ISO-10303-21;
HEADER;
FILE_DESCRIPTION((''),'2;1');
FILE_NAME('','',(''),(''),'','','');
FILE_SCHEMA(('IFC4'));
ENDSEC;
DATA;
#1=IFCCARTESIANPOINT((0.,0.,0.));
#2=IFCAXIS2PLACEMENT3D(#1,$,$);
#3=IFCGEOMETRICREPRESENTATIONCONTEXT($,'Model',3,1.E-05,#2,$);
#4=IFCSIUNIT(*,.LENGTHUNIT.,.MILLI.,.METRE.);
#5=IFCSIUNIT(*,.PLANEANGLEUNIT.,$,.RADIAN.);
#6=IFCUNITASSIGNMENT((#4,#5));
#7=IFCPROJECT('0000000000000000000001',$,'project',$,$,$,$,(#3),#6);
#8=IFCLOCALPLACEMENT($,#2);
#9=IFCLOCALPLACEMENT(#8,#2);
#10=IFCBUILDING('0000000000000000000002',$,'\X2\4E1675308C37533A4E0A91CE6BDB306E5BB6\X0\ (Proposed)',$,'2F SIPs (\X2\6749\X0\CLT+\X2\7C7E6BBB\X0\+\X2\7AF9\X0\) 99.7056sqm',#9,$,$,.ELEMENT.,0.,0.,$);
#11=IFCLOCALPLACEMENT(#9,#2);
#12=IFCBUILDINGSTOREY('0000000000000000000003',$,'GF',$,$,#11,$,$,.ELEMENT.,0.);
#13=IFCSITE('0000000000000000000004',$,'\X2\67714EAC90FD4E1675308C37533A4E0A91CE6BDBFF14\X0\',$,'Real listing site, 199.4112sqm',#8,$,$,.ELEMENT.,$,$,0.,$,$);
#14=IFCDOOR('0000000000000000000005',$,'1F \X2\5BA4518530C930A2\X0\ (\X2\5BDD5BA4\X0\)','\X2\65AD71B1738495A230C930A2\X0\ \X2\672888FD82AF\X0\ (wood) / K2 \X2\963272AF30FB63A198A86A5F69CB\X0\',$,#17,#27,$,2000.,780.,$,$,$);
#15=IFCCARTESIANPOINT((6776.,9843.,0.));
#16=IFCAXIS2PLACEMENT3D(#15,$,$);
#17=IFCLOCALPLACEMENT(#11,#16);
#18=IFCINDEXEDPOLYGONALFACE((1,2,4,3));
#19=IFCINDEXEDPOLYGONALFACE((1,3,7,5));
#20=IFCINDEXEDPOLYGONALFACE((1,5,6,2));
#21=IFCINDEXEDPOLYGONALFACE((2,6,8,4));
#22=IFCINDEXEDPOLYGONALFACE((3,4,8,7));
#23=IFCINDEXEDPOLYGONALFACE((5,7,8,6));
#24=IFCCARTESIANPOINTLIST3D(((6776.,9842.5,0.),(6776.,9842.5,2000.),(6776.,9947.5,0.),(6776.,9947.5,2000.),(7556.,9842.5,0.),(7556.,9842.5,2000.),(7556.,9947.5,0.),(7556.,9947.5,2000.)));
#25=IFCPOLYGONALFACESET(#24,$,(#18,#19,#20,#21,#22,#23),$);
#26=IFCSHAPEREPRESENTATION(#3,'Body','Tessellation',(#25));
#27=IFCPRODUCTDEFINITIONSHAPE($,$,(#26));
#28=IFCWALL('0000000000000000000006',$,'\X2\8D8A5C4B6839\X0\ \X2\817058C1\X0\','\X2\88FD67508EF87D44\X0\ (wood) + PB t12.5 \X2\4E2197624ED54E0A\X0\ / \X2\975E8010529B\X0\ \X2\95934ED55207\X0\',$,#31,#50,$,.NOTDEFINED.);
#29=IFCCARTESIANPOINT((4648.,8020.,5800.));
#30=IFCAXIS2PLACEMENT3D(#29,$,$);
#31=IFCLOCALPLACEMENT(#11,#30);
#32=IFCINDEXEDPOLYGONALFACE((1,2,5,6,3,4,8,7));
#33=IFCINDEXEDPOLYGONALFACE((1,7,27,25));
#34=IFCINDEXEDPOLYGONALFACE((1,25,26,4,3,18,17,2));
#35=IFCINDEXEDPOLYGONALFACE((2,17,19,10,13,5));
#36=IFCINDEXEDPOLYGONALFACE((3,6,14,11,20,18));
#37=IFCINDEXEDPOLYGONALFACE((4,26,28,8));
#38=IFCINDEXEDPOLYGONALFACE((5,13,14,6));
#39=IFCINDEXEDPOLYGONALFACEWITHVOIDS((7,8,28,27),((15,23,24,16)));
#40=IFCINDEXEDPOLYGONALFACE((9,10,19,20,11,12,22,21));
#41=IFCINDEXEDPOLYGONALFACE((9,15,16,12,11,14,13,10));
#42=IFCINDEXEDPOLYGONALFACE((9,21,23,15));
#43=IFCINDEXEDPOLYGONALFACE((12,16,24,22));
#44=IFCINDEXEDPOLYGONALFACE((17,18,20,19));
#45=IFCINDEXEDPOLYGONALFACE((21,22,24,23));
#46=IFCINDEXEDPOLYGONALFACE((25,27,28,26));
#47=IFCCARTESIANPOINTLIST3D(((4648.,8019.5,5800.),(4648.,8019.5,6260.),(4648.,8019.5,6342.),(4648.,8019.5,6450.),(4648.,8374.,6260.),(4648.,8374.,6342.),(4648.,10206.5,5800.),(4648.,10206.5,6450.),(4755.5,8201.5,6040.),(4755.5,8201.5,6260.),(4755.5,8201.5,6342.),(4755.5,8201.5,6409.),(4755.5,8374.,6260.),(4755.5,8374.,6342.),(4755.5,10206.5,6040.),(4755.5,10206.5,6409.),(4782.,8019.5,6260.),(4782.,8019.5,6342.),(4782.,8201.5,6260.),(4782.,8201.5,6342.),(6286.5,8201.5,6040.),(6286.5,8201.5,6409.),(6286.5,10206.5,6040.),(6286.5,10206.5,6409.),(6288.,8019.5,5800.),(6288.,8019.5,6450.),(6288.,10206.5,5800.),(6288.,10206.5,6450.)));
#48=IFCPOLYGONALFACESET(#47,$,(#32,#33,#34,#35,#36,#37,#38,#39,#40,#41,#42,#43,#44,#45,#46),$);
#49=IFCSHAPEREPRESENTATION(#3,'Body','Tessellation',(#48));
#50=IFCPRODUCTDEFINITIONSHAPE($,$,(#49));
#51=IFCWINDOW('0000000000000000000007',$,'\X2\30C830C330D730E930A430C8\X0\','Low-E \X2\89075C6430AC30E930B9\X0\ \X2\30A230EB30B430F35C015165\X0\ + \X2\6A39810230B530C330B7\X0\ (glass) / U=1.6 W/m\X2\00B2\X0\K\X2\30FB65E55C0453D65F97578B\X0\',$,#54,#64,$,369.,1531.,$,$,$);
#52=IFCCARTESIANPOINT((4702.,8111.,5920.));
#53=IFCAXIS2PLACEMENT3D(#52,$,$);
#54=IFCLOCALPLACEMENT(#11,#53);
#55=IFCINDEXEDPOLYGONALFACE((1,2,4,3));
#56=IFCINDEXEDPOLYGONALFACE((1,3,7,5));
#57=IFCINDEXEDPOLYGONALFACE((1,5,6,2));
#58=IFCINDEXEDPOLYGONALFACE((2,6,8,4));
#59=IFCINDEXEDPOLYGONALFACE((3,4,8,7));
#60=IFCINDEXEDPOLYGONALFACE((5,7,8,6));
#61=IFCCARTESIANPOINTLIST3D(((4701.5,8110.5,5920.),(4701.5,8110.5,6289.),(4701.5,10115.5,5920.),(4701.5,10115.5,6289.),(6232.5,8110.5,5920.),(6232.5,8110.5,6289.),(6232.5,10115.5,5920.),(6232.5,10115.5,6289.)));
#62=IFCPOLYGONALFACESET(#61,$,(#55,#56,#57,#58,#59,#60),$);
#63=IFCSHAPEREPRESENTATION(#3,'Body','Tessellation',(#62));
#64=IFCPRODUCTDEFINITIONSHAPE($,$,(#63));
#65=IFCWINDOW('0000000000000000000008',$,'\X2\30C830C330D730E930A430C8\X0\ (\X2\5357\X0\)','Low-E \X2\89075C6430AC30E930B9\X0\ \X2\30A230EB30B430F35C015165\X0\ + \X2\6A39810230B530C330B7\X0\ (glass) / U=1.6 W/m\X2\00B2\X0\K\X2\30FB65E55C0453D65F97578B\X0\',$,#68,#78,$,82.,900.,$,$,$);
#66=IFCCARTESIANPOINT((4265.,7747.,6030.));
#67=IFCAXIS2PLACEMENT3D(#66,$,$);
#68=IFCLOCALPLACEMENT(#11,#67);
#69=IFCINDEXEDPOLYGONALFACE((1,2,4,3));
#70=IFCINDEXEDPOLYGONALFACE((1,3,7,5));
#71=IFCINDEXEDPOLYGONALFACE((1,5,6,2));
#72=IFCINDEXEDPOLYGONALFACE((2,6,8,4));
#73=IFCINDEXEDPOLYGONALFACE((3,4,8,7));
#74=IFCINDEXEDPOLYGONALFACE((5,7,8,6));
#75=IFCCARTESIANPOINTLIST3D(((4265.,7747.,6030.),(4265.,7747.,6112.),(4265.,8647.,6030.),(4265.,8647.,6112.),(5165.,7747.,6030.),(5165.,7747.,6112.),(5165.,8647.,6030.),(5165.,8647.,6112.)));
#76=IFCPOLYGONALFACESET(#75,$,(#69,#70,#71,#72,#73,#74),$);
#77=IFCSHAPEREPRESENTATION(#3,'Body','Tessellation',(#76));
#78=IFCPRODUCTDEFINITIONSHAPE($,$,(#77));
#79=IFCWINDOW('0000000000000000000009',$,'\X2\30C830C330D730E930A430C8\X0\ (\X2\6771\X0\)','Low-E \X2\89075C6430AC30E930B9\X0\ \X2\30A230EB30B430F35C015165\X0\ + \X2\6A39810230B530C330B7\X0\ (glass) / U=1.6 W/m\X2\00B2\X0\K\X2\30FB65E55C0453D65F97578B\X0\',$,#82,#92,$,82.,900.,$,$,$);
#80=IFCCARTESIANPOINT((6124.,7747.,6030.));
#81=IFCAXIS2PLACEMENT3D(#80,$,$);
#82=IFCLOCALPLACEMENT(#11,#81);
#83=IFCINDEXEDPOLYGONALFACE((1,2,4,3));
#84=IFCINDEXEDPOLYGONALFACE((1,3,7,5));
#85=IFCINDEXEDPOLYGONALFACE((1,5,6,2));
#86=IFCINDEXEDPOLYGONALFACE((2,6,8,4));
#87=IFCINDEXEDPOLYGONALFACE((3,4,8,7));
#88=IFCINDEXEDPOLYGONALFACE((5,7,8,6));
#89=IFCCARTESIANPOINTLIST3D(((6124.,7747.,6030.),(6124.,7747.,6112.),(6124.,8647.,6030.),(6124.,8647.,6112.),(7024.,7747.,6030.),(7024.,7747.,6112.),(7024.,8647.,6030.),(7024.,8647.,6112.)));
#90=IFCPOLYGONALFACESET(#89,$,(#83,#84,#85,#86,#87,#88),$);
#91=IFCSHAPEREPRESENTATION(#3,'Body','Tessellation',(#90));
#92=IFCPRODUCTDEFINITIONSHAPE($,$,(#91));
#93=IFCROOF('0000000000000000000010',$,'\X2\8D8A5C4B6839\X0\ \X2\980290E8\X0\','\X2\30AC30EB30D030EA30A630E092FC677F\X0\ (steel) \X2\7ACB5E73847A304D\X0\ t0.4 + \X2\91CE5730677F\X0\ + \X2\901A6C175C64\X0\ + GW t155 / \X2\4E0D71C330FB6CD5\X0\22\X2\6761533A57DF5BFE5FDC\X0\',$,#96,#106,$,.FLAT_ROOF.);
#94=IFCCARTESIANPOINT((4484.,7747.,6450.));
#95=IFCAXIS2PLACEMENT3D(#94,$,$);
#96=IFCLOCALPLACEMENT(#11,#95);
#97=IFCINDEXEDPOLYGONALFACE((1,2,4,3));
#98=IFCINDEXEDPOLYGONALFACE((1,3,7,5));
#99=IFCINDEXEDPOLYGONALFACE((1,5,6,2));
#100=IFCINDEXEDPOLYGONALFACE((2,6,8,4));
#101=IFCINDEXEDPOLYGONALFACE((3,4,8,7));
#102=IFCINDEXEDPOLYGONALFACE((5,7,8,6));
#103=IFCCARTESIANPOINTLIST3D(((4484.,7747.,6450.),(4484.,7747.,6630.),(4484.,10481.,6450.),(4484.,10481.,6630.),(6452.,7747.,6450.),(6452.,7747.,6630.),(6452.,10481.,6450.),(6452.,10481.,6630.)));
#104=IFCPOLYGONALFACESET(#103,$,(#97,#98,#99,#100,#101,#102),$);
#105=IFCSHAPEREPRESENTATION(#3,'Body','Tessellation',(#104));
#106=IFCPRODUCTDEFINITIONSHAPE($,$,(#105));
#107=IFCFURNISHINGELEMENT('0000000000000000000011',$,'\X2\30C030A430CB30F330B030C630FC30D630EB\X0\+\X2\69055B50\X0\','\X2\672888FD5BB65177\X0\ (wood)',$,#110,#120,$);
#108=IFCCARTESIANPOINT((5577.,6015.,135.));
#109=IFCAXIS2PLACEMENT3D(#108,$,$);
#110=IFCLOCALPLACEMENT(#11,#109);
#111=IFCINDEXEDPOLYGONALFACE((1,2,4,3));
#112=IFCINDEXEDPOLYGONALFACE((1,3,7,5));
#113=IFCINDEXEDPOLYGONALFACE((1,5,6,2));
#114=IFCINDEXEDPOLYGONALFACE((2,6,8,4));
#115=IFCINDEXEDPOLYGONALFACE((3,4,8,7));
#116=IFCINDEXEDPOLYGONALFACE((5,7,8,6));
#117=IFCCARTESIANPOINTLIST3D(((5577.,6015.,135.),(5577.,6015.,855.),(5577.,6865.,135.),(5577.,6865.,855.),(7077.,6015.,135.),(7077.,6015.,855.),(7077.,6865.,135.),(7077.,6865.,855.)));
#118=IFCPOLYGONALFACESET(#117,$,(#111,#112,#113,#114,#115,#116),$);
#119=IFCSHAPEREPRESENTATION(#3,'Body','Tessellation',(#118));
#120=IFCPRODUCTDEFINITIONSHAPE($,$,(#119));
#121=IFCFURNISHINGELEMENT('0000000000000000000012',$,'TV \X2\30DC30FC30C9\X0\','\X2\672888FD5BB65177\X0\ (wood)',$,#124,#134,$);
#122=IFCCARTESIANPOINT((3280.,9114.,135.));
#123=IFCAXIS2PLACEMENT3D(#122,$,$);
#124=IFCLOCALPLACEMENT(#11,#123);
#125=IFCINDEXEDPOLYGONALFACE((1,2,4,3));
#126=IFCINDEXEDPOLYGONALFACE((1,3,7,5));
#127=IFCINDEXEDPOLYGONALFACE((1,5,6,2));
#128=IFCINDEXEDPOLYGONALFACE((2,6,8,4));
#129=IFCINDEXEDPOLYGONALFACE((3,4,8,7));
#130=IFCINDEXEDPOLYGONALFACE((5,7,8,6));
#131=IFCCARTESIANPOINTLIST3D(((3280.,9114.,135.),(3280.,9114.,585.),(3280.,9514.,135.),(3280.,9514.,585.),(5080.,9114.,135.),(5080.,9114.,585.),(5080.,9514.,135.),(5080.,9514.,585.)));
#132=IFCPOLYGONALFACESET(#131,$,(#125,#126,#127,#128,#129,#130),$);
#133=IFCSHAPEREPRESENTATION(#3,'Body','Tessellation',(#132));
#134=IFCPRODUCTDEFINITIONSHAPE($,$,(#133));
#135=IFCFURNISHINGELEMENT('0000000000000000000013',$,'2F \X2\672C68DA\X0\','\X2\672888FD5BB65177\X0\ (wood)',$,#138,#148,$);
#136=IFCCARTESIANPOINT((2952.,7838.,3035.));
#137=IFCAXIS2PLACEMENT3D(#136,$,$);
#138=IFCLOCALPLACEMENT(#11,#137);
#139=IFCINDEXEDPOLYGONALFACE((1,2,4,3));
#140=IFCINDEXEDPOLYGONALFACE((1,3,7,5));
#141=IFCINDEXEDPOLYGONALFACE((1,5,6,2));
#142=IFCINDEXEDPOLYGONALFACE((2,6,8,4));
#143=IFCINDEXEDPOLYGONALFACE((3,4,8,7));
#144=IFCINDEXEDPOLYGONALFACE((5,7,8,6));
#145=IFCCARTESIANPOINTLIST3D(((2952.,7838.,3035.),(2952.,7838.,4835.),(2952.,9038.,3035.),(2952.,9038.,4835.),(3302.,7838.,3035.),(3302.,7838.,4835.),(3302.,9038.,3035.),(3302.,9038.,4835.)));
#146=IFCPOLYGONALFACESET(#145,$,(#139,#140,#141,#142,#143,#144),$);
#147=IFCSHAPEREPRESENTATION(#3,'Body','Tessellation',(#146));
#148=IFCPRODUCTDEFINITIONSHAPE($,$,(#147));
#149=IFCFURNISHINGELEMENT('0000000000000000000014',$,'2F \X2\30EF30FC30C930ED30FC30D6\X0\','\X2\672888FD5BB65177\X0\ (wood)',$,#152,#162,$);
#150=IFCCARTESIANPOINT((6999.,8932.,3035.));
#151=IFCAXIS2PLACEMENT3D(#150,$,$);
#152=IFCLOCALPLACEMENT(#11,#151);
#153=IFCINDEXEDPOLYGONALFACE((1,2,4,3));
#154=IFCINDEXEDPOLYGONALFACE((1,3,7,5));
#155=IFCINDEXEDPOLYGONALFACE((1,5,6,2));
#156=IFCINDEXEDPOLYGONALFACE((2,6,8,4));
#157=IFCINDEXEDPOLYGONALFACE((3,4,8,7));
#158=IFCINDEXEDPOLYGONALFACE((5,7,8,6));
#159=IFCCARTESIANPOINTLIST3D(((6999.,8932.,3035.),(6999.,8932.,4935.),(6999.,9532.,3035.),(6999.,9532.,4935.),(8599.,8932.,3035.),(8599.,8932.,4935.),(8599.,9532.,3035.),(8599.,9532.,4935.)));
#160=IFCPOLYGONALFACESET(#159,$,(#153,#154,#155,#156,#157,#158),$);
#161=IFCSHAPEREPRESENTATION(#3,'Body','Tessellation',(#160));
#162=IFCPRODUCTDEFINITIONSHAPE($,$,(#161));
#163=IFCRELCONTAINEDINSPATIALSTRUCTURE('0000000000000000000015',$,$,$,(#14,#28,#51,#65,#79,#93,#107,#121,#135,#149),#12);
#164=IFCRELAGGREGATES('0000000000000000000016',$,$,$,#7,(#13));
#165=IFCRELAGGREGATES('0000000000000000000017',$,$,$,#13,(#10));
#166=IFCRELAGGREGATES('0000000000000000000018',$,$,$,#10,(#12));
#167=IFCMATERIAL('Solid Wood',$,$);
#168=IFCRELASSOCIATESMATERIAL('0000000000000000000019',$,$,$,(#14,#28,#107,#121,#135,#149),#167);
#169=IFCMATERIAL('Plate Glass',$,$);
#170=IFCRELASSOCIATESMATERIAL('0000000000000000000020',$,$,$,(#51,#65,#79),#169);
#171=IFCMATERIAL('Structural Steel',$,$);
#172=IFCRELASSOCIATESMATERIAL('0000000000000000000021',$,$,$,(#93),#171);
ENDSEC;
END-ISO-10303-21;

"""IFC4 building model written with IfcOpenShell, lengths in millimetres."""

from ifc_helpers import new_model, si_unit, frame, frame_2d, origin, place, context, project, spatial, rectangle, extrude, material, element, fill, save


model = new_model("IFC4")

# Units and contexts
model_context = context("Model", 3, precision=1e-05, world=origin())
ifc_project = project(units=[si_unit("LENGTHUNIT", "METRE", prefix="MILLI"), si_unit("PLANEANGLEUNIT", "RADIAN")], contexts=[model_context])

# Site, building, storey
site_placement = place(None, origin())
site = spatial("IfcSite", under=ifc_project, at=site_placement, Name="東京都世田谷区上野毛４", ObjectType="Real listing site, 199.4112sqm", CompositionType="ELEMENT", RefElevation=0.0)
building_placement = place(site_placement, origin())
building = spatial("IfcBuilding", under=site, at=building_placement, Name="世田谷区上野毛の家 (Proposed)", ObjectType="2F SIPs (杉CLT+籾殻+竹) 99.7056sqm", CompositionType="ELEMENT", ElevationOfRefHeight=0.0, ElevationOfTerrain=0.0)
storey_placement = place(building_placement, origin())
storey = spatial("IfcBuildingStorey", under=building, at=storey_placement, Name="GF", CompositionType="ELEMENT", Elevation=0.0)

# Shared definitions
ifc_material_1 = material(Name="Solid Wood")

# Door
door_placement = place(storey_placement, frame((6776.0, 9843.0, 0.0)))
element("IfcDoor", 1, at=door_placement, inside=storey, material=ifc_material_1, Name="1F 室内ドア (寝室)", Description="断熱玄関ドア 木製芯 (wood) / K2 防犯・採風機構", OverallHeight=2000.0, OverallWidth=780.0, context=model_context, shape_type="SweptSolid", body=[
    extrude(rectangle(XDim=780.0, YDim=105.0, at=frame_2d((390.0, 52.0))), frame((6776.0, 9843.0, 0.0)), (0.0, 0.0, 1.0), 2000.0),
])

# Wall, openings, windows
wall_1_placement = place(storey_placement, frame((4648.0, 8020.0, 5800.0)))
wall_1 = element("IfcWall", 2, at=wall_1_placement, inside=storey, material=ifc_material_1, Name="越屋根 腰壁", Description="製材軸組 (wood) + PB t12.5 両面仕上 / 非耐力 間仕切", PredefinedType="NOTDEFINED", context=model_context, shape_type="SweptSolid", body=[
    extrude(rectangle(XDim=1640.0, YDim=2187.0, at=frame_2d((820.0, 1093.0))), frame((4648.0, 8020.0, 5800.0)), (0.0, 0.0, 1.0), 650.0),
])
opening_1_placement = place(storey_placement, frame((4702.0, 8111.0, 5920.0)))
opening_1 = element("IfcOpeningElement", 3, at=opening_1_placement, cuts=wall_1, PredefinedType="NOTDEFINED", context=model_context, shape_type="SweptSolid", body=[
    extrude(rectangle(XDim=1531.0, YDim=2005.0, at=frame_2d((765.0, 1002.0))), frame((4702.0, 8111.0, 5920.0)), (0.0, 0.0, 1.0), 369.0),
])
opening_2_placement = place(storey_placement, frame((4265.0, 7747.0, 6030.0)))
opening_2 = element("IfcOpeningElement", 4, at=opening_2_placement, cuts=wall_1, PredefinedType="NOTDEFINED", context=model_context, shape_type="SweptSolid", body=[
    extrude(rectangle(XDim=900.0, YDim=900.0, at=frame_2d((450.0, 450.0))), frame((4265.0, 7747.0, 6030.0)), (0.0, 0.0, 1.0), 82.0),
])
opening_3_placement = place(storey_placement, frame((6124.0, 7747.0, 6030.0)))
opening_3 = element("IfcOpeningElement", 5, at=opening_3_placement, cuts=wall_1, PredefinedType="NOTDEFINED", context=model_context, shape_type="SweptSolid", body=[
    extrude(rectangle(XDim=900.0, YDim=900.0, at=frame_2d((450.0, 450.0))), frame((6124.0, 7747.0, 6030.0)), (0.0, 0.0, 1.0), 82.0),
])
ifc_material_2 = material(Name="Plate Glass")
window_1_placement = place(storey_placement, frame((4702.0, 8111.0, 5920.0)))
window_1 = element("IfcWindow", 6, at=window_1_placement, inside=storey, material=ifc_material_2, Name="トップライト", Description="Low-E 複層ガラス アルゴン封入 + 樹脂サッシ (glass) / U=1.6 W/m²K・日射取得型", OverallHeight=369.0, OverallWidth=1531.0, context=model_context, shape_type="SweptSolid", body=[
    extrude(rectangle(XDim=1531.0, YDim=2005.0, at=frame_2d((765.0, 1002.0))), frame((4702.0, 8111.0, 5920.0)), (0.0, 0.0, 1.0), 369.0),
])
fill(opening_1, window_1)
window_2_placement = place(storey_placement, frame((4265.0, 7747.0, 6030.0)))
window_2 = element("IfcWindow", 7, at=window_2_placement, inside=storey, material=ifc_material_2, Name="トップライト (南)", Description="Low-E 複層ガラス アルゴン封入 + 樹脂サッシ (glass) / U=1.6 W/m²K・日射取得型", OverallHeight=82.0, OverallWidth=900.0, context=model_context, shape_type="SweptSolid", body=[
    extrude(rectangle(XDim=900.0, YDim=900.0, at=frame_2d((450.0, 450.0))), frame((4265.0, 7747.0, 6030.0)), (0.0, 0.0, 1.0), 82.0),
])
fill(opening_2, window_2)
window_3_placement = place(storey_placement, frame((6124.0, 7747.0, 6030.0)))
window_3 = element("IfcWindow", 8, at=window_3_placement, inside=storey, material=ifc_material_2, Name="トップライト (東)", Description="Low-E 複層ガラス アルゴン封入 + 樹脂サッシ (glass) / U=1.6 W/m²K・日射取得型", OverallHeight=82.0, OverallWidth=900.0, context=model_context, shape_type="SweptSolid", body=[
    extrude(rectangle(XDim=900.0, YDim=900.0, at=frame_2d((450.0, 450.0))), frame((6124.0, 7747.0, 6030.0)), (0.0, 0.0, 1.0), 82.0),
])
fill(opening_3, window_3)

# Roof
ifc_material_3 = material(Name="Structural Steel")
roof_placement = place(storey_placement, frame((4484.0, 7747.0, 6450.0)))
element("IfcRoof", 9, at=roof_placement, inside=storey, material=ifc_material_3, Name="越屋根 頂部", Description="ガルバリウム鋼板 (steel) 立平葺き t0.4 + 野地板 + 通気層 + GW t155 / 不燃・法22条区域対応", PredefinedType="FLAT_ROOF", context=model_context, shape_type="SweptSolid", body=[
    extrude(rectangle(XDim=1968.0, YDim=2734.0, at=frame_2d((984.0, 1367.0))), frame((4484.0, 7747.0, 6450.0)), (0.0, 0.0, 1.0), 180.0),
])

# Furnishing elements
furnishing_1_placement = place(storey_placement, frame((5577.0, 6015.0, 135.0)))
element("IfcFurnishingElement", 10, at=furnishing_1_placement, inside=storey, material=ifc_material_1, Name="ダイニングテーブル+椅子", Description="木製家具 (wood)", context=model_context, shape_type="SweptSolid", body=[
    extrude(rectangle(XDim=1500.0, YDim=850.0, at=frame_2d((750.0, 425.0))), frame((5577.0, 6015.0, 135.0)), (0.0, 0.0, 1.0), 720.0),
])
furnishing_2_placement = place(storey_placement, frame((3280.0, 9114.0, 135.0)))
element("IfcFurnishingElement", 11, at=furnishing_2_placement, inside=storey, material=ifc_material_1, Name="TV ボード", Description="木製家具 (wood)", context=model_context, shape_type="SweptSolid", body=[
    extrude(rectangle(XDim=1800.0, YDim=400.0, at=frame_2d((900.0, 200.0))), frame((3280.0, 9114.0, 135.0)), (0.0, 0.0, 1.0), 450.0),
])
furnishing_3_placement = place(storey_placement, frame((2952.0, 7838.0, 3035.0)))
element("IfcFurnishingElement", 12, at=furnishing_3_placement, inside=storey, material=ifc_material_1, Name="2F 本棚", Description="木製家具 (wood)", context=model_context, shape_type="SweptSolid", body=[
    extrude(rectangle(XDim=350.0, YDim=1200.0, at=frame_2d((175.0, 600.0))), frame((2952.0, 7838.0, 3035.0)), (0.0, 0.0, 1.0), 1800.0),
])
furnishing_4_placement = place(storey_placement, frame((6999.0, 8932.0, 3035.0)))
element("IfcFurnishingElement", 13, at=furnishing_4_placement, inside=storey, material=ifc_material_1, Name="2F ワードローブ", Description="木製家具 (wood)", context=model_context, shape_type="SweptSolid", body=[
    extrude(rectangle(XDim=1600.0, YDim=600.0, at=frame_2d((800.0, 300.0))), frame((6999.0, 8932.0, 3035.0)), (0.0, 0.0, 1.0), 1900.0),
])

save(model, "model.ifc")
